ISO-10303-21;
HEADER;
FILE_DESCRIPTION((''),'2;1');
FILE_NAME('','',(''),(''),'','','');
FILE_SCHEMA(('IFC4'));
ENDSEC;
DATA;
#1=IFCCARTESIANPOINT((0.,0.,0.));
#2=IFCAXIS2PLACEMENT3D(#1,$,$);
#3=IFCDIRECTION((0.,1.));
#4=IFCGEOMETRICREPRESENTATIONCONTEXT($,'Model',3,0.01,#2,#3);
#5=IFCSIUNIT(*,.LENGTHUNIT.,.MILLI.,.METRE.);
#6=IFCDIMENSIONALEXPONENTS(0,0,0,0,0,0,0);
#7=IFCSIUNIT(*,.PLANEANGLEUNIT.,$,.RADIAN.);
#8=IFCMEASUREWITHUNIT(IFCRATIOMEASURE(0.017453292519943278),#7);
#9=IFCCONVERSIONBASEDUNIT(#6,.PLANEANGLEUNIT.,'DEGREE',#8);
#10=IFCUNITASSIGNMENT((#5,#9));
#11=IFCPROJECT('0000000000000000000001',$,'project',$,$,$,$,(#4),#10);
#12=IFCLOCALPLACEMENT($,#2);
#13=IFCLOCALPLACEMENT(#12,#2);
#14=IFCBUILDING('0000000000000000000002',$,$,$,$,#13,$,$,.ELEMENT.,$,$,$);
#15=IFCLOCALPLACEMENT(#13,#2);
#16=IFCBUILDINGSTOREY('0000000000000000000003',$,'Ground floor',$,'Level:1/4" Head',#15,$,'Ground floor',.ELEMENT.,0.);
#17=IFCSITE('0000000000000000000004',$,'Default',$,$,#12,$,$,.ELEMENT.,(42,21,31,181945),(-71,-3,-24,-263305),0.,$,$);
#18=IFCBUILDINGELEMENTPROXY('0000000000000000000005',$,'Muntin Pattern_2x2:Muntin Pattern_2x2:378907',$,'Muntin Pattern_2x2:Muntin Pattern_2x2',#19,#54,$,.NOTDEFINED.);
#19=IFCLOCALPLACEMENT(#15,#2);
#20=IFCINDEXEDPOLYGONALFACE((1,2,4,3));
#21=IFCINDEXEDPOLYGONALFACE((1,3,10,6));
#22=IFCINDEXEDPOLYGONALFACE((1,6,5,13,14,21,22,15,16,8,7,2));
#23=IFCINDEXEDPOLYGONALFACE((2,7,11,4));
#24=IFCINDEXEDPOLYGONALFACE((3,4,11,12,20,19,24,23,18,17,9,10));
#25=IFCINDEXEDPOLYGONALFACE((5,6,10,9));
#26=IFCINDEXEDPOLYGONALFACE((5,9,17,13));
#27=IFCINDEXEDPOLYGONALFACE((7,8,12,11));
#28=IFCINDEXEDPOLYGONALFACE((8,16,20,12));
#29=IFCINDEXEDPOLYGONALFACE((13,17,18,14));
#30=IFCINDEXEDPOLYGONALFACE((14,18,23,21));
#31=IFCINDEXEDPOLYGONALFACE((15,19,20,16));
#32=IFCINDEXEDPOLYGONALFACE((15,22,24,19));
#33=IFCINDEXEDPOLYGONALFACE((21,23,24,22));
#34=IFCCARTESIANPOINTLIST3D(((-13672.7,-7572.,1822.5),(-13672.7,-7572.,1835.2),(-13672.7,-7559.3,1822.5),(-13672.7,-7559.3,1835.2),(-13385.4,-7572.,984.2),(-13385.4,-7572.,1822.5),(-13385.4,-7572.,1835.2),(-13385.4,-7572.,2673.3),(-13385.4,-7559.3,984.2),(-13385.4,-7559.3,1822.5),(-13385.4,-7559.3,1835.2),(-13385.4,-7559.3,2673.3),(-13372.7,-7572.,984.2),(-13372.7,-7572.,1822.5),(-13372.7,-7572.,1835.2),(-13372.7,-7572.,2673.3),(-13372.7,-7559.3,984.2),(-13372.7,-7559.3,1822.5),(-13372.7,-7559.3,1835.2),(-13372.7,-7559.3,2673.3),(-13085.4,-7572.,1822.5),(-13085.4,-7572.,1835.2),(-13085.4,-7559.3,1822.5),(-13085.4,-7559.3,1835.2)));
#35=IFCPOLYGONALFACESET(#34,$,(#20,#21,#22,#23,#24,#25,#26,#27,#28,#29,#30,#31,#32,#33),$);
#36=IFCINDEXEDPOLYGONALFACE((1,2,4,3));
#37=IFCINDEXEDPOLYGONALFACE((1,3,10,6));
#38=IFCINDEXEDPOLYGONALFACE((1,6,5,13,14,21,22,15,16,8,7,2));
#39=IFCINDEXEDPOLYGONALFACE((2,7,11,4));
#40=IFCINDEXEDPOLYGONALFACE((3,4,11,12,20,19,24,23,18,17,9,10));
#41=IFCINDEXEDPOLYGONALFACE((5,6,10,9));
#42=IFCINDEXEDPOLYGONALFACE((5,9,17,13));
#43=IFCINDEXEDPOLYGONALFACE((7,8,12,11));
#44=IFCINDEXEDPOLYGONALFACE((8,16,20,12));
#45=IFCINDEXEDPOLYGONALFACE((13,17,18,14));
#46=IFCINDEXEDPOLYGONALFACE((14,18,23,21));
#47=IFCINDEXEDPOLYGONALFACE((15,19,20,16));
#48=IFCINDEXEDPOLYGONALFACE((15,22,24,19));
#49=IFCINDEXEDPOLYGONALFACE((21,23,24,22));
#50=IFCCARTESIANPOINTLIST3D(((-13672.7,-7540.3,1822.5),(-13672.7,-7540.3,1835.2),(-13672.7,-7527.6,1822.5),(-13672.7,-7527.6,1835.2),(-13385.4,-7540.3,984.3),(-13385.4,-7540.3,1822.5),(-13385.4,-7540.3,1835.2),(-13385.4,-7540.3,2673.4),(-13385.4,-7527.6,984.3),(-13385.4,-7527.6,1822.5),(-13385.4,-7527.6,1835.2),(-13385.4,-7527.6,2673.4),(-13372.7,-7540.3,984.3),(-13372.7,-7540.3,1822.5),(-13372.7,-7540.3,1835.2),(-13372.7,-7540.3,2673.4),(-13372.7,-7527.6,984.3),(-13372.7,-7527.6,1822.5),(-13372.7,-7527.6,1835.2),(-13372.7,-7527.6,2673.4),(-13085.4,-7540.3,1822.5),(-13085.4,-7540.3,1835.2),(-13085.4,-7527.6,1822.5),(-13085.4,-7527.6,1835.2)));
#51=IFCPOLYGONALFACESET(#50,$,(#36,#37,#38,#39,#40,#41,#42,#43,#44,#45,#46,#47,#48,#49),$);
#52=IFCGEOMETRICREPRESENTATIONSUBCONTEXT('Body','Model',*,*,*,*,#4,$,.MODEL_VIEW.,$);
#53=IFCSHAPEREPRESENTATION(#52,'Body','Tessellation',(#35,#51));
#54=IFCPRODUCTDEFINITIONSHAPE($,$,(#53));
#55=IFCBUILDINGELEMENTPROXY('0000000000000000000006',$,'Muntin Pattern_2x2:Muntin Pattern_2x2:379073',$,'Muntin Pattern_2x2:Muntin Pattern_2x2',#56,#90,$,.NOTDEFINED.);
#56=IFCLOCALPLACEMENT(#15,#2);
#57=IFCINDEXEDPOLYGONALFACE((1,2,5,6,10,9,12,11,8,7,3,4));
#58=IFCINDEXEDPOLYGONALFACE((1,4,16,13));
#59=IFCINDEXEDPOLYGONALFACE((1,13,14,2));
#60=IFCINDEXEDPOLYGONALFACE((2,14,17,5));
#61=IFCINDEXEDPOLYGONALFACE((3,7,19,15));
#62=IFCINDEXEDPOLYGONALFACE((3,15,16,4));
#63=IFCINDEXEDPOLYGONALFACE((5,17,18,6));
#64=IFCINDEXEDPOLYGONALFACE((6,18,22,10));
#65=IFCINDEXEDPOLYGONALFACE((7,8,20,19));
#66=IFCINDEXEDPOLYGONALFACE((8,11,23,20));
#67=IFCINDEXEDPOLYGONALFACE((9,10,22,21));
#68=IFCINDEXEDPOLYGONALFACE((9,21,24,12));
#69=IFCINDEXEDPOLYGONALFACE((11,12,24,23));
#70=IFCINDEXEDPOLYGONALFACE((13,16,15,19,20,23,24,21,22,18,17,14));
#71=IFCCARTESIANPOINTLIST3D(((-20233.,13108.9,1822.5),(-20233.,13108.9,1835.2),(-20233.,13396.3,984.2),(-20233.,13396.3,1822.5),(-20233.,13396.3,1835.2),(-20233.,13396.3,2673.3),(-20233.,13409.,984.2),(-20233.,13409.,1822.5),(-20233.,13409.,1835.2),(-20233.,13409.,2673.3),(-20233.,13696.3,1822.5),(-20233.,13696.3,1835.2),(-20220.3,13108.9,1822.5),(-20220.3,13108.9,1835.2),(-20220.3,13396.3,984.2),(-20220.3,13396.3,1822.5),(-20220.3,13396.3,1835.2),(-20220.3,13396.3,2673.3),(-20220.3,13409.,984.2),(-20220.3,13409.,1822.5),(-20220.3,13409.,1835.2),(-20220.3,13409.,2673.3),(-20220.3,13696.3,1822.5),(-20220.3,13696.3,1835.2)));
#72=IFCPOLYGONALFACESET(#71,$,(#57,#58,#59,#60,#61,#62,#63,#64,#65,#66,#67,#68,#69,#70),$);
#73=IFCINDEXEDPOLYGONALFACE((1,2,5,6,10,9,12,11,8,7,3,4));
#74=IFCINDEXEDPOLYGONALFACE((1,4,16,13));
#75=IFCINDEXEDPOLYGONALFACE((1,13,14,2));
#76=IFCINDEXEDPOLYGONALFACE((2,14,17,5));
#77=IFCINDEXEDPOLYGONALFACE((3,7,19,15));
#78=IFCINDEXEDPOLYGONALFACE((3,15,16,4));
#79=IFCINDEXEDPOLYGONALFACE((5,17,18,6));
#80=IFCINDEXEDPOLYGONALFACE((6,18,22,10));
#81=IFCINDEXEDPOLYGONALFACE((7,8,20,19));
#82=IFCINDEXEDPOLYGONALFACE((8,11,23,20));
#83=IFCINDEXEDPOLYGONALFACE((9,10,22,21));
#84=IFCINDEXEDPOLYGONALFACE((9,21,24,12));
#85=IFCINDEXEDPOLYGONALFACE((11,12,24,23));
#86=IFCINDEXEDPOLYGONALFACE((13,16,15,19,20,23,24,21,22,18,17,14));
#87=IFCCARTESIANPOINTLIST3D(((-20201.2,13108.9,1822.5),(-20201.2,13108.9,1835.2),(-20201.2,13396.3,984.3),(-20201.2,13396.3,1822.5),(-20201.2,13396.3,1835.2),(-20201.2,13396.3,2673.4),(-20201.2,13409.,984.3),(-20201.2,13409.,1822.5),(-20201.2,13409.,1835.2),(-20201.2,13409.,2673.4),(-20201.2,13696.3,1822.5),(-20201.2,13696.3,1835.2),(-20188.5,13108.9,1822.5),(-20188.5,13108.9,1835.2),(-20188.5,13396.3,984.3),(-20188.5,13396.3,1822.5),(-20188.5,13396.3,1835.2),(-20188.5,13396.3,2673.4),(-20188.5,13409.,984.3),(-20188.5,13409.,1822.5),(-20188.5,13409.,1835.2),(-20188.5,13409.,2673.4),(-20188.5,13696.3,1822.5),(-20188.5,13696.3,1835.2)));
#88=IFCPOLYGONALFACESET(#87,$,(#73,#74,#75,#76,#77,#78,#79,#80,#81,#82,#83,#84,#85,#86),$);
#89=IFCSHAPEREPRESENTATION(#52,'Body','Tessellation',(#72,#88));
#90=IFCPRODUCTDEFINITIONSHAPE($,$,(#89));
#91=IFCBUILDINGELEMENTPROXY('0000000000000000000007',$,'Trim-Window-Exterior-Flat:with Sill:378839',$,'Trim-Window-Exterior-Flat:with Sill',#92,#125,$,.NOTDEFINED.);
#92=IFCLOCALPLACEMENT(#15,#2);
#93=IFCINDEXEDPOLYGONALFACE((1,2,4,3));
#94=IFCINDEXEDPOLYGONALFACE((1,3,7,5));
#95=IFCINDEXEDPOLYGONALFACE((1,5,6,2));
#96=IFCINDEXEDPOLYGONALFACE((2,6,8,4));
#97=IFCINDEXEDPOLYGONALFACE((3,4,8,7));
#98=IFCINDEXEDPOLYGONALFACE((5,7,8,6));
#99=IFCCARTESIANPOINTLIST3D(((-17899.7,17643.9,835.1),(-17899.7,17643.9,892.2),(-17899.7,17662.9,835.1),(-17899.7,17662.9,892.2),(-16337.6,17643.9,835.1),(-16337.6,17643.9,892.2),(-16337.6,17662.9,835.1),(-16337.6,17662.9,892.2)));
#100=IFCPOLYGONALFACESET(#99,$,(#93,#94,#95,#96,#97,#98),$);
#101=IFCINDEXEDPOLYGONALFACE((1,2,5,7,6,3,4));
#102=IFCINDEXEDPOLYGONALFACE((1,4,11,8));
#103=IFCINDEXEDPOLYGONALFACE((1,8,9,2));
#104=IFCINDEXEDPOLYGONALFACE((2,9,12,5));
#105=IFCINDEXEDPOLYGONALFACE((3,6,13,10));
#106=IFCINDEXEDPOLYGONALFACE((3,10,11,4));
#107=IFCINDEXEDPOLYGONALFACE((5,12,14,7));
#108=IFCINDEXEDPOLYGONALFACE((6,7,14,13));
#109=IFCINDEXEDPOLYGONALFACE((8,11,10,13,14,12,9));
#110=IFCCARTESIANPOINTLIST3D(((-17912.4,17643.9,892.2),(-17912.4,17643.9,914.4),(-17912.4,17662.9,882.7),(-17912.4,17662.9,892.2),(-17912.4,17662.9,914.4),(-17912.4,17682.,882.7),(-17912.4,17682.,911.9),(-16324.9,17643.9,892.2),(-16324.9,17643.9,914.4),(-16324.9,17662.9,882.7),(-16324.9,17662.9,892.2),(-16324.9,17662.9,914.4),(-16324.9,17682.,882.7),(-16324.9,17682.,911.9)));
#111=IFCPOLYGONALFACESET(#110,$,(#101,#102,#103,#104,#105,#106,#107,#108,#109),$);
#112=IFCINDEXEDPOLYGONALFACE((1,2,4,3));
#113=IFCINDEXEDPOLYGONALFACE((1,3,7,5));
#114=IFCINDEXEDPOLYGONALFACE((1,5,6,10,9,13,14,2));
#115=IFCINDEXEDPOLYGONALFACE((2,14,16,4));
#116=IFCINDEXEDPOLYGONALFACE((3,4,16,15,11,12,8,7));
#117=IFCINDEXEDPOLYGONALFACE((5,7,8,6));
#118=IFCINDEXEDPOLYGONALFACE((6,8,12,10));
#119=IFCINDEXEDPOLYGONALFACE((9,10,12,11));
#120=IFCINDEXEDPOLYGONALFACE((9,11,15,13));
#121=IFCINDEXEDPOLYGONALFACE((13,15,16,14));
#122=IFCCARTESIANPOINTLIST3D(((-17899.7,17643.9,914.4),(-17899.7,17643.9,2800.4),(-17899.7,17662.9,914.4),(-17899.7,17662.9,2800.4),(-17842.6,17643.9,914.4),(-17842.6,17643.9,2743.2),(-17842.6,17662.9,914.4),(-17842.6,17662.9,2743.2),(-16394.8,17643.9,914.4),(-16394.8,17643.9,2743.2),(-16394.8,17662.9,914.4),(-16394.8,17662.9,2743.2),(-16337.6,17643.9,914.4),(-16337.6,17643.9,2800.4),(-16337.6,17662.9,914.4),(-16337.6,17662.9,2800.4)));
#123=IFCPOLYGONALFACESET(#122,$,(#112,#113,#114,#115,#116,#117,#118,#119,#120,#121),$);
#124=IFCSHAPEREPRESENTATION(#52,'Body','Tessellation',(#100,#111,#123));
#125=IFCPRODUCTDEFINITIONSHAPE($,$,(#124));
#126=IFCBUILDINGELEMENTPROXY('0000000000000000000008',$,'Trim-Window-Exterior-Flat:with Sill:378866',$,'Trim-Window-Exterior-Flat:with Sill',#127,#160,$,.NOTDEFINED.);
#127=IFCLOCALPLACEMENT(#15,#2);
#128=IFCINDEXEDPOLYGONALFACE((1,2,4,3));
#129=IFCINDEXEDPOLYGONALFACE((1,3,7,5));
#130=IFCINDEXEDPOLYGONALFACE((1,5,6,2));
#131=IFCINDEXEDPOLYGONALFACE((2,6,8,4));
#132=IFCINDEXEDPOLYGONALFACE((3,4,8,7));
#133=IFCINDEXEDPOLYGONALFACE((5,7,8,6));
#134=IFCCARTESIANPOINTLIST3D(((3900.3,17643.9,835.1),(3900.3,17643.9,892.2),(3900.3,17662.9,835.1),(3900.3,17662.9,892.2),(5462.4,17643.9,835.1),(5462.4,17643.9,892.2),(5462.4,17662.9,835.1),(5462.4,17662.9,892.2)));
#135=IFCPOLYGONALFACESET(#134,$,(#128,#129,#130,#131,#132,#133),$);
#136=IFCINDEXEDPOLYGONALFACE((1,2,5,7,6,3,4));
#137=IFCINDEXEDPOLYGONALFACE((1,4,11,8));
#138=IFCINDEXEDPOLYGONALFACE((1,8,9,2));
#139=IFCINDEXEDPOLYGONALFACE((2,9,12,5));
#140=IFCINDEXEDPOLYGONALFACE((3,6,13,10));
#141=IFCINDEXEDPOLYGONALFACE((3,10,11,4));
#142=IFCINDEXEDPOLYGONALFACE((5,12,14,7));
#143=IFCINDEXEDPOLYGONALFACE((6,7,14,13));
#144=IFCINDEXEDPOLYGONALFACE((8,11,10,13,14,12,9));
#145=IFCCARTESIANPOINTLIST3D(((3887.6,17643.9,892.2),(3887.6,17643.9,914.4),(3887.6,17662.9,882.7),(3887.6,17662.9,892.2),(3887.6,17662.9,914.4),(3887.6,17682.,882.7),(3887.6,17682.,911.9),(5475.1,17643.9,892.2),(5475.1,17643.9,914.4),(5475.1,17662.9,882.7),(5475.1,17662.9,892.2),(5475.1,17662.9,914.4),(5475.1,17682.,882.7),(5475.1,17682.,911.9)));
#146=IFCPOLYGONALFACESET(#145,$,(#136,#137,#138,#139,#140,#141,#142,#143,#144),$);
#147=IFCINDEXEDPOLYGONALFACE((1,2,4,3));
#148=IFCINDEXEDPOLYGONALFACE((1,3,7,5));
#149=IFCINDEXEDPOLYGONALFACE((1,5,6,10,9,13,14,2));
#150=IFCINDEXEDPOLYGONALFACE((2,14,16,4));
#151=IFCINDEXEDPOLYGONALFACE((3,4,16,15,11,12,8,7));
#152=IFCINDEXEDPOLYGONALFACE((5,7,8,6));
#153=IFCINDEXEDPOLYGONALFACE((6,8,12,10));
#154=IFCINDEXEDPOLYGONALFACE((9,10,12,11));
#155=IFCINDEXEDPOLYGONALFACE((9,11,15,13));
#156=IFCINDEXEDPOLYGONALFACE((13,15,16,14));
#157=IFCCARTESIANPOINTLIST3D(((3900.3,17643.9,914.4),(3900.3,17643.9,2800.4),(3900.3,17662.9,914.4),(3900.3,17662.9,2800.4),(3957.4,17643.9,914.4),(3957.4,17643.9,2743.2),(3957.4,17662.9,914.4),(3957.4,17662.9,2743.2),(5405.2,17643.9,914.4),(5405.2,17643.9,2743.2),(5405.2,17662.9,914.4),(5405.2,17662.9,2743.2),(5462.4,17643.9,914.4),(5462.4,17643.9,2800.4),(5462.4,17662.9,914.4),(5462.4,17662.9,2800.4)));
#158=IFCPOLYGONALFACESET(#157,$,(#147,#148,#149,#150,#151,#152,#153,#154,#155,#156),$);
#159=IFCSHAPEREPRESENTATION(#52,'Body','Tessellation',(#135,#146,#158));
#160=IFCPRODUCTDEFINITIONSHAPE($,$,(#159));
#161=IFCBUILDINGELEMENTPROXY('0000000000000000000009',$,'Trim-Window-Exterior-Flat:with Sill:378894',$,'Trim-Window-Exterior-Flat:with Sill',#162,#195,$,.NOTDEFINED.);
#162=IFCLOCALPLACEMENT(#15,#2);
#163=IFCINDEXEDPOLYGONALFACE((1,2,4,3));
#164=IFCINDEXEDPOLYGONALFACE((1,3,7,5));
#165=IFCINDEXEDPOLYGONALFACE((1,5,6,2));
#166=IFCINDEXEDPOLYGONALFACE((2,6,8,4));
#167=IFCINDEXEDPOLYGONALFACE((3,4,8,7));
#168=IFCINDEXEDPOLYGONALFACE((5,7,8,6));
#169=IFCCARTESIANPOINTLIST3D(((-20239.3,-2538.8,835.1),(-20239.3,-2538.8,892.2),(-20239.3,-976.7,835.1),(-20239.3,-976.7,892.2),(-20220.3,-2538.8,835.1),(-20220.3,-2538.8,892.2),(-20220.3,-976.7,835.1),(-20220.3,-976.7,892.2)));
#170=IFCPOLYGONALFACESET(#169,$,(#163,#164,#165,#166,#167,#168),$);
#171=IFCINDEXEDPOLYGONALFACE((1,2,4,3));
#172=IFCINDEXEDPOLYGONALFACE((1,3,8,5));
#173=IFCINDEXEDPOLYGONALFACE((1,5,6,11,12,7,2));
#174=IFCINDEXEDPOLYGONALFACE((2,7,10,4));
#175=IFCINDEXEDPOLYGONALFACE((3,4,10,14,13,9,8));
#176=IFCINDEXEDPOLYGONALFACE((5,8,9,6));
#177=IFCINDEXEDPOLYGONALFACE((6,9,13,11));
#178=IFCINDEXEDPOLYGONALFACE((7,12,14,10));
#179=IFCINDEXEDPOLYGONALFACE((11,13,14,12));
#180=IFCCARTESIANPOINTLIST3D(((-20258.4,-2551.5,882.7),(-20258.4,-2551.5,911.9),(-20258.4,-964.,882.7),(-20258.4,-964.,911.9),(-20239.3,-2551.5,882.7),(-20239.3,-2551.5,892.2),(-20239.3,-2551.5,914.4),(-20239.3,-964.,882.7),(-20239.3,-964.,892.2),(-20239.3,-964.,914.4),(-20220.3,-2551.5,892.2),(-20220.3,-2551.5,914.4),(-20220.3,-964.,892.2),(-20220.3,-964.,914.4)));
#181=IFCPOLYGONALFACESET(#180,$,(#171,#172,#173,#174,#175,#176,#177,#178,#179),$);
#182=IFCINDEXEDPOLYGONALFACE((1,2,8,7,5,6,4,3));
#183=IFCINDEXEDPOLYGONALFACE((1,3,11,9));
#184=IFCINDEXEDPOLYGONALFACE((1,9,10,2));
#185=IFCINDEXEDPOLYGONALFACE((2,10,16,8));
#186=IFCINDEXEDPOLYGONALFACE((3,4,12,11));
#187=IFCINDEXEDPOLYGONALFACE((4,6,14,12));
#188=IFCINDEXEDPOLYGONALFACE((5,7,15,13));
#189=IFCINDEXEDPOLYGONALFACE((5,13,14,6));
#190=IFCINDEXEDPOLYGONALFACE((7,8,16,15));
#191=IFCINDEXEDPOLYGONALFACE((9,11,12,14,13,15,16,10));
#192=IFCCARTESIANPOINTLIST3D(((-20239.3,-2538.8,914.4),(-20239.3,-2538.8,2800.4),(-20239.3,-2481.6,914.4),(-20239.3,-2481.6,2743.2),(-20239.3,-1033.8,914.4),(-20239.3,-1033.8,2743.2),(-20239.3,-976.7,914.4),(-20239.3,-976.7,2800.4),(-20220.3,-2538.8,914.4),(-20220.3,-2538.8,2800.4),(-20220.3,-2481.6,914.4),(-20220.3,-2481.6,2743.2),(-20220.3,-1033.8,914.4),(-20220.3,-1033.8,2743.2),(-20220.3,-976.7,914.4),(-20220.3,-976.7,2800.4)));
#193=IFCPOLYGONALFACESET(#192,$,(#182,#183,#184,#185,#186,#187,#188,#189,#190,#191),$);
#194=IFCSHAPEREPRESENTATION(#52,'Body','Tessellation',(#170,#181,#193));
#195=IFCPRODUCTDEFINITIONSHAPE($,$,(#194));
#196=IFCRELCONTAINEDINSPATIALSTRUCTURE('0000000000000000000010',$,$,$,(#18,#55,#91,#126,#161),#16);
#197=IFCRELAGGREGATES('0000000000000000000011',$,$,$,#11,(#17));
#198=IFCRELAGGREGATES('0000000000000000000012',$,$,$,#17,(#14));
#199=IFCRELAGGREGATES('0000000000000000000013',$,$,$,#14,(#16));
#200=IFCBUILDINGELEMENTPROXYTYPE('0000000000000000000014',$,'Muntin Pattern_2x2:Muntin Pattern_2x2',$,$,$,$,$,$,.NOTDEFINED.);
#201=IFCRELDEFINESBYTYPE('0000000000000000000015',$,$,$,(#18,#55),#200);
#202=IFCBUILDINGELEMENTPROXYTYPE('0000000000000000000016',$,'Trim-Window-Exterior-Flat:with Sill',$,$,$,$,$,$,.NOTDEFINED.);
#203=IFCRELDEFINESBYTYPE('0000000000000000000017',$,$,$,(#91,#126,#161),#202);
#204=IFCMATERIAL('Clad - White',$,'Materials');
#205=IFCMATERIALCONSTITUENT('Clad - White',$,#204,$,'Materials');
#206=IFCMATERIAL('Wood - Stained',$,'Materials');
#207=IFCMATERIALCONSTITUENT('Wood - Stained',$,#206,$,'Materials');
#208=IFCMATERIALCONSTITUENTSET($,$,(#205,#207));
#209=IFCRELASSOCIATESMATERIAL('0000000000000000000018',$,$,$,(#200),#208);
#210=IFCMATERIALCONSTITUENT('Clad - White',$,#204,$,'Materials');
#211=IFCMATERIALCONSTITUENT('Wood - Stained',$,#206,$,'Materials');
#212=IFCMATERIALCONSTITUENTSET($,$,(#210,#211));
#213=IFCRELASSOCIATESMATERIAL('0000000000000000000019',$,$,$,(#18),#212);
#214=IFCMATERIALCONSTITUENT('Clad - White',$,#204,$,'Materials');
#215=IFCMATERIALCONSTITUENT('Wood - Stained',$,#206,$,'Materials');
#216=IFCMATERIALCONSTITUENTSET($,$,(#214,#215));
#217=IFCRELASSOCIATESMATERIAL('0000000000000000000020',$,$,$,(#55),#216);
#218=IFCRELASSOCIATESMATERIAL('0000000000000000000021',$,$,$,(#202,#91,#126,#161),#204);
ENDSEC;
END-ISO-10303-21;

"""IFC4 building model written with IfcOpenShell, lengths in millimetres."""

from ifc_helpers import new_model, entity, si_unit, converted_unit, direction, frame, origin, place, context, subcontext, project, spatial, indexed_curve, outline, extrude, source, transform, mapped, material, constituent, constituent_set, type_object, type_shapes, element, save


model = new_model("IFC4")

# Units and contexts
model_context = context("Model", 3, precision=0.01, world=origin(), true_north=direction((0.0, 1.0)))
body_context = subcontext(model_context, "Body", "Model", "MODEL_VIEW")
ifc_project = project(units=[si_unit("LENGTHUNIT", "METRE", prefix="MILLI"), converted_unit("PLANEANGLEUNIT", "DEGREE", entity("IfcRatioMeasure", 0.017453292519943278), si_unit("PLANEANGLEUNIT", "RADIAN"), dimensions=[0, 0, 0, 0, 0, 0, 0])], contexts=[model_context])

# Site, building, storey
site_placement = place(None, origin())
site = spatial("IfcSite", under=ifc_project, at=site_placement, Name="Default", CompositionType="ELEMENT", RefLatitude=(42, 21, 31, 181945), RefLongitude=(-71, -3, -24, -263305), RefElevation=0.0)
building_placement = place(site_placement, origin())
building = spatial("IfcBuilding", under=site, at=building_placement, CompositionType="ELEMENT")
storey_placement = place(building_placement, origin())
storey = spatial("IfcBuildingStorey", under=building, at=storey_placement, Name="Ground floor", ObjectType="Level:1/4\" Head", LongName="Ground floor", CompositionType="ELEMENT", Elevation=0.0)

# Building element proxies
ifc_material_1 = material(Name="Clad - White", Category="Materials")
ifc_material_2 = material(Name="Wood - Stained", Category="Materials")
ifc_constituent_1 = constituent(ifc_material_1, Name="Clad - White", Category="Materials")
ifc_constituent_2 = constituent(ifc_material_2, Name="Wood - Stained", Category="Materials")
ifc_constituent_set_1 = constituent_set(constituents=[ifc_constituent_1, ifc_constituent_2])
building_element_proxy_type_1 = type_object("IfcBuildingElementProxyType", Name="Muntin Pattern_2x2:Muntin Pattern_2x2", PredefinedType="NOTDEFINED", material=ifc_constituent_set_1)
shared_shape_1 = source(origin(), body_context, "Body", "SweptSolid", [
    extrude(outline(indexed_curve([(6.4, -6.4), (844.5, -6.4), (844.5, 6.3), (6.4, 6.3), (6.4, 293.7), (-6.3, 293.7), (-6.3, 6.3), (-844.6, 6.3), (-844.6, -6.4), (-6.3, -6.4), (-6.3, -293.7), (6.4, -293.7), (6.4, -6.4)], self_intersect=False)), frame((0.0, -22.2, 844.5), z_axis=(0.0, 1.0, 0.0), x_axis=(0.0, 0.0, 1.0)), (0.0, 0.0, 1.0), 12.7),
    extrude(outline(indexed_curve([(6.4, -6.4), (844.6, -6.4), (844.6, 6.3), (6.4, 6.3), (6.4, 293.7), (-6.3, 293.7), (-6.3, 6.3), (-844.6, 6.3), (-844.6, -6.4), (-6.3, -6.4), (-6.3, -293.7), (6.4, -293.7), (6.4, -6.4)], self_intersect=False)), frame((0.0, 9.5, 844.6), z_axis=(0.0, 1.0, 0.0), x_axis=(0.0, 0.0, 1.0)), (0.0, 0.0, 1.0), 12.7),
])
type_shapes(building_element_proxy_type_1, [shared_shape_1])
ifc_constituent_3 = constituent(ifc_material_1, Name="Clad - White", Category="Materials")
ifc_constituent_4 = constituent(ifc_material_2, Name="Wood - Stained", Category="Materials")
ifc_constituent_set_2 = constituent_set(constituents=[ifc_constituent_3, ifc_constituent_4])
proxy_1_placement = place(storey_placement, frame((-13379.1, -7549.8, 984.3)))
element("IfcBuildingElementProxy", 1, at=proxy_1_placement, inside=storey, type_object=building_element_proxy_type_1, material=ifc_constituent_set_2, Name="Muntin Pattern_2x2:Muntin Pattern_2x2:378907", ObjectType="Muntin Pattern_2x2:Muntin Pattern_2x2", PredefinedType="NOTDEFINED", context=body_context, shape_type="MappedRepresentation", body=[
    mapped(shared_shape_1, transform((0.0, 0.0, 0.0), scale=1.0)),
])
ifc_constituent_5 = constituent(ifc_material_1, Name="Clad - White", Category="Materials")
ifc_constituent_6 = constituent(ifc_material_2, Name="Wood - Stained", Category="Materials")
ifc_constituent_set_3 = constituent_set(constituents=[ifc_constituent_5, ifc_constituent_6])
proxy_2_placement = place(storey_placement, frame((-20210.8, 13402.6, 984.3), z_axis=(0.0, 0.0, 1.0), x_axis=(0.0, -1.0, 0.0)))
element("IfcBuildingElementProxy", 2, at=proxy_2_placement, inside=storey, type_object=building_element_proxy_type_1, material=ifc_constituent_set_3, Name="Muntin Pattern_2x2:Muntin Pattern_2x2:379073", ObjectType="Muntin Pattern_2x2:Muntin Pattern_2x2", PredefinedType="NOTDEFINED", context=body_context, shape_type="MappedRepresentation", body=[
    mapped(shared_shape_1, transform((0.0, 0.0, 0.0), scale=1.0)),
])
building_element_proxy_type_2 = type_object("IfcBuildingElementProxyType", Name="Trim-Window-Exterior-Flat:with Sill", PredefinedType="NOTDEFINED", material=ifc_material_1)
shared_shape_2 = source(origin(), body_context, "Body", "SweptSolid", [
    extrude(outline(indexed_curve([(-781.0, -28.6), (781.0, -28.6), (781.0, 28.6), (-781.0, 28.6), (-781.0, -28.6)], self_intersect=False)), frame((0.0, -1879.6, 0.0), z_axis=(0.0, 0.0, 1.0), x_axis=(-1.0, 0.0, 0.0)), (0.0, 0.0, 1.0), 19.0),
    extrude(outline(indexed_curve([(-19.0, -16.0), (0.0, -16.0), (0.0, -6.4), (19.0, -6.4), (19.0, 15.8), (0.0, 15.8), (-19.0, 13.3), (-19.0, -16.0)], self_intersect=False)), frame((-793.7, -1844.6, 19.0), z_axis=(1.0, 0.0, 0.0), x_axis=(0.0, 0.0, -1.0)), (0.0, 0.0, 1.0), 1587.5),
    extrude(outline(indexed_curve([(-957.3, -781.0), (928.7, -781.0), (928.7, -723.9), (-900.1, -723.9), (-900.1, 723.9), (928.7, 723.9), (928.7, 781.0), (-957.3, 781.0), (-957.3, -781.0)], self_intersect=False)), frame((0.0, -900.1, 0.0), z_axis=(0.0, 0.0, 1.0), x_axis=(0.0, -1.0, 0.0)), (0.0, 0.0, 1.0), 19.0),
])
type_shapes(building_element_proxy_type_2, [shared_shape_2])
for number, where, z_axis, x_axis, name in (
    (3, (-17118.7, 17643.9, 2743.2), (0.0, 1.0, 0.0), (-1.0, 0.0, 0.0), "Trim-Window-Exterior-Flat:with Sill:378839"),
    (4, (4681.3, 17643.9, 2743.2), (0.0, 1.0, 0.0), (-1.0, 0.0, 0.0), "Trim-Window-Exterior-Flat:with Sill:378866"),
    (5, (-20220.3, -1757.7, 2743.2), (-1.0, 0.0, 0.0), (0.0, -1.0, 0.0), "Trim-Window-Exterior-Flat:with Sill:378894"),
):
    element("IfcBuildingElementProxy", number, at=place(storey_placement, frame(where, z_axis=z_axis, x_axis=x_axis)), inside=storey, type_object=building_element_proxy_type_2, material=ifc_material_1, Name=name, ObjectType="Trim-Window-Exterior-Flat:with Sill", PredefinedType="NOTDEFINED", context=body_context, shape_type="MappedRepresentation", body=[
        mapped(shared_shape_2, transform((0.0, 0.0, 0.0), scale=1.0)),
    ])

save(model, "model.ifc")
